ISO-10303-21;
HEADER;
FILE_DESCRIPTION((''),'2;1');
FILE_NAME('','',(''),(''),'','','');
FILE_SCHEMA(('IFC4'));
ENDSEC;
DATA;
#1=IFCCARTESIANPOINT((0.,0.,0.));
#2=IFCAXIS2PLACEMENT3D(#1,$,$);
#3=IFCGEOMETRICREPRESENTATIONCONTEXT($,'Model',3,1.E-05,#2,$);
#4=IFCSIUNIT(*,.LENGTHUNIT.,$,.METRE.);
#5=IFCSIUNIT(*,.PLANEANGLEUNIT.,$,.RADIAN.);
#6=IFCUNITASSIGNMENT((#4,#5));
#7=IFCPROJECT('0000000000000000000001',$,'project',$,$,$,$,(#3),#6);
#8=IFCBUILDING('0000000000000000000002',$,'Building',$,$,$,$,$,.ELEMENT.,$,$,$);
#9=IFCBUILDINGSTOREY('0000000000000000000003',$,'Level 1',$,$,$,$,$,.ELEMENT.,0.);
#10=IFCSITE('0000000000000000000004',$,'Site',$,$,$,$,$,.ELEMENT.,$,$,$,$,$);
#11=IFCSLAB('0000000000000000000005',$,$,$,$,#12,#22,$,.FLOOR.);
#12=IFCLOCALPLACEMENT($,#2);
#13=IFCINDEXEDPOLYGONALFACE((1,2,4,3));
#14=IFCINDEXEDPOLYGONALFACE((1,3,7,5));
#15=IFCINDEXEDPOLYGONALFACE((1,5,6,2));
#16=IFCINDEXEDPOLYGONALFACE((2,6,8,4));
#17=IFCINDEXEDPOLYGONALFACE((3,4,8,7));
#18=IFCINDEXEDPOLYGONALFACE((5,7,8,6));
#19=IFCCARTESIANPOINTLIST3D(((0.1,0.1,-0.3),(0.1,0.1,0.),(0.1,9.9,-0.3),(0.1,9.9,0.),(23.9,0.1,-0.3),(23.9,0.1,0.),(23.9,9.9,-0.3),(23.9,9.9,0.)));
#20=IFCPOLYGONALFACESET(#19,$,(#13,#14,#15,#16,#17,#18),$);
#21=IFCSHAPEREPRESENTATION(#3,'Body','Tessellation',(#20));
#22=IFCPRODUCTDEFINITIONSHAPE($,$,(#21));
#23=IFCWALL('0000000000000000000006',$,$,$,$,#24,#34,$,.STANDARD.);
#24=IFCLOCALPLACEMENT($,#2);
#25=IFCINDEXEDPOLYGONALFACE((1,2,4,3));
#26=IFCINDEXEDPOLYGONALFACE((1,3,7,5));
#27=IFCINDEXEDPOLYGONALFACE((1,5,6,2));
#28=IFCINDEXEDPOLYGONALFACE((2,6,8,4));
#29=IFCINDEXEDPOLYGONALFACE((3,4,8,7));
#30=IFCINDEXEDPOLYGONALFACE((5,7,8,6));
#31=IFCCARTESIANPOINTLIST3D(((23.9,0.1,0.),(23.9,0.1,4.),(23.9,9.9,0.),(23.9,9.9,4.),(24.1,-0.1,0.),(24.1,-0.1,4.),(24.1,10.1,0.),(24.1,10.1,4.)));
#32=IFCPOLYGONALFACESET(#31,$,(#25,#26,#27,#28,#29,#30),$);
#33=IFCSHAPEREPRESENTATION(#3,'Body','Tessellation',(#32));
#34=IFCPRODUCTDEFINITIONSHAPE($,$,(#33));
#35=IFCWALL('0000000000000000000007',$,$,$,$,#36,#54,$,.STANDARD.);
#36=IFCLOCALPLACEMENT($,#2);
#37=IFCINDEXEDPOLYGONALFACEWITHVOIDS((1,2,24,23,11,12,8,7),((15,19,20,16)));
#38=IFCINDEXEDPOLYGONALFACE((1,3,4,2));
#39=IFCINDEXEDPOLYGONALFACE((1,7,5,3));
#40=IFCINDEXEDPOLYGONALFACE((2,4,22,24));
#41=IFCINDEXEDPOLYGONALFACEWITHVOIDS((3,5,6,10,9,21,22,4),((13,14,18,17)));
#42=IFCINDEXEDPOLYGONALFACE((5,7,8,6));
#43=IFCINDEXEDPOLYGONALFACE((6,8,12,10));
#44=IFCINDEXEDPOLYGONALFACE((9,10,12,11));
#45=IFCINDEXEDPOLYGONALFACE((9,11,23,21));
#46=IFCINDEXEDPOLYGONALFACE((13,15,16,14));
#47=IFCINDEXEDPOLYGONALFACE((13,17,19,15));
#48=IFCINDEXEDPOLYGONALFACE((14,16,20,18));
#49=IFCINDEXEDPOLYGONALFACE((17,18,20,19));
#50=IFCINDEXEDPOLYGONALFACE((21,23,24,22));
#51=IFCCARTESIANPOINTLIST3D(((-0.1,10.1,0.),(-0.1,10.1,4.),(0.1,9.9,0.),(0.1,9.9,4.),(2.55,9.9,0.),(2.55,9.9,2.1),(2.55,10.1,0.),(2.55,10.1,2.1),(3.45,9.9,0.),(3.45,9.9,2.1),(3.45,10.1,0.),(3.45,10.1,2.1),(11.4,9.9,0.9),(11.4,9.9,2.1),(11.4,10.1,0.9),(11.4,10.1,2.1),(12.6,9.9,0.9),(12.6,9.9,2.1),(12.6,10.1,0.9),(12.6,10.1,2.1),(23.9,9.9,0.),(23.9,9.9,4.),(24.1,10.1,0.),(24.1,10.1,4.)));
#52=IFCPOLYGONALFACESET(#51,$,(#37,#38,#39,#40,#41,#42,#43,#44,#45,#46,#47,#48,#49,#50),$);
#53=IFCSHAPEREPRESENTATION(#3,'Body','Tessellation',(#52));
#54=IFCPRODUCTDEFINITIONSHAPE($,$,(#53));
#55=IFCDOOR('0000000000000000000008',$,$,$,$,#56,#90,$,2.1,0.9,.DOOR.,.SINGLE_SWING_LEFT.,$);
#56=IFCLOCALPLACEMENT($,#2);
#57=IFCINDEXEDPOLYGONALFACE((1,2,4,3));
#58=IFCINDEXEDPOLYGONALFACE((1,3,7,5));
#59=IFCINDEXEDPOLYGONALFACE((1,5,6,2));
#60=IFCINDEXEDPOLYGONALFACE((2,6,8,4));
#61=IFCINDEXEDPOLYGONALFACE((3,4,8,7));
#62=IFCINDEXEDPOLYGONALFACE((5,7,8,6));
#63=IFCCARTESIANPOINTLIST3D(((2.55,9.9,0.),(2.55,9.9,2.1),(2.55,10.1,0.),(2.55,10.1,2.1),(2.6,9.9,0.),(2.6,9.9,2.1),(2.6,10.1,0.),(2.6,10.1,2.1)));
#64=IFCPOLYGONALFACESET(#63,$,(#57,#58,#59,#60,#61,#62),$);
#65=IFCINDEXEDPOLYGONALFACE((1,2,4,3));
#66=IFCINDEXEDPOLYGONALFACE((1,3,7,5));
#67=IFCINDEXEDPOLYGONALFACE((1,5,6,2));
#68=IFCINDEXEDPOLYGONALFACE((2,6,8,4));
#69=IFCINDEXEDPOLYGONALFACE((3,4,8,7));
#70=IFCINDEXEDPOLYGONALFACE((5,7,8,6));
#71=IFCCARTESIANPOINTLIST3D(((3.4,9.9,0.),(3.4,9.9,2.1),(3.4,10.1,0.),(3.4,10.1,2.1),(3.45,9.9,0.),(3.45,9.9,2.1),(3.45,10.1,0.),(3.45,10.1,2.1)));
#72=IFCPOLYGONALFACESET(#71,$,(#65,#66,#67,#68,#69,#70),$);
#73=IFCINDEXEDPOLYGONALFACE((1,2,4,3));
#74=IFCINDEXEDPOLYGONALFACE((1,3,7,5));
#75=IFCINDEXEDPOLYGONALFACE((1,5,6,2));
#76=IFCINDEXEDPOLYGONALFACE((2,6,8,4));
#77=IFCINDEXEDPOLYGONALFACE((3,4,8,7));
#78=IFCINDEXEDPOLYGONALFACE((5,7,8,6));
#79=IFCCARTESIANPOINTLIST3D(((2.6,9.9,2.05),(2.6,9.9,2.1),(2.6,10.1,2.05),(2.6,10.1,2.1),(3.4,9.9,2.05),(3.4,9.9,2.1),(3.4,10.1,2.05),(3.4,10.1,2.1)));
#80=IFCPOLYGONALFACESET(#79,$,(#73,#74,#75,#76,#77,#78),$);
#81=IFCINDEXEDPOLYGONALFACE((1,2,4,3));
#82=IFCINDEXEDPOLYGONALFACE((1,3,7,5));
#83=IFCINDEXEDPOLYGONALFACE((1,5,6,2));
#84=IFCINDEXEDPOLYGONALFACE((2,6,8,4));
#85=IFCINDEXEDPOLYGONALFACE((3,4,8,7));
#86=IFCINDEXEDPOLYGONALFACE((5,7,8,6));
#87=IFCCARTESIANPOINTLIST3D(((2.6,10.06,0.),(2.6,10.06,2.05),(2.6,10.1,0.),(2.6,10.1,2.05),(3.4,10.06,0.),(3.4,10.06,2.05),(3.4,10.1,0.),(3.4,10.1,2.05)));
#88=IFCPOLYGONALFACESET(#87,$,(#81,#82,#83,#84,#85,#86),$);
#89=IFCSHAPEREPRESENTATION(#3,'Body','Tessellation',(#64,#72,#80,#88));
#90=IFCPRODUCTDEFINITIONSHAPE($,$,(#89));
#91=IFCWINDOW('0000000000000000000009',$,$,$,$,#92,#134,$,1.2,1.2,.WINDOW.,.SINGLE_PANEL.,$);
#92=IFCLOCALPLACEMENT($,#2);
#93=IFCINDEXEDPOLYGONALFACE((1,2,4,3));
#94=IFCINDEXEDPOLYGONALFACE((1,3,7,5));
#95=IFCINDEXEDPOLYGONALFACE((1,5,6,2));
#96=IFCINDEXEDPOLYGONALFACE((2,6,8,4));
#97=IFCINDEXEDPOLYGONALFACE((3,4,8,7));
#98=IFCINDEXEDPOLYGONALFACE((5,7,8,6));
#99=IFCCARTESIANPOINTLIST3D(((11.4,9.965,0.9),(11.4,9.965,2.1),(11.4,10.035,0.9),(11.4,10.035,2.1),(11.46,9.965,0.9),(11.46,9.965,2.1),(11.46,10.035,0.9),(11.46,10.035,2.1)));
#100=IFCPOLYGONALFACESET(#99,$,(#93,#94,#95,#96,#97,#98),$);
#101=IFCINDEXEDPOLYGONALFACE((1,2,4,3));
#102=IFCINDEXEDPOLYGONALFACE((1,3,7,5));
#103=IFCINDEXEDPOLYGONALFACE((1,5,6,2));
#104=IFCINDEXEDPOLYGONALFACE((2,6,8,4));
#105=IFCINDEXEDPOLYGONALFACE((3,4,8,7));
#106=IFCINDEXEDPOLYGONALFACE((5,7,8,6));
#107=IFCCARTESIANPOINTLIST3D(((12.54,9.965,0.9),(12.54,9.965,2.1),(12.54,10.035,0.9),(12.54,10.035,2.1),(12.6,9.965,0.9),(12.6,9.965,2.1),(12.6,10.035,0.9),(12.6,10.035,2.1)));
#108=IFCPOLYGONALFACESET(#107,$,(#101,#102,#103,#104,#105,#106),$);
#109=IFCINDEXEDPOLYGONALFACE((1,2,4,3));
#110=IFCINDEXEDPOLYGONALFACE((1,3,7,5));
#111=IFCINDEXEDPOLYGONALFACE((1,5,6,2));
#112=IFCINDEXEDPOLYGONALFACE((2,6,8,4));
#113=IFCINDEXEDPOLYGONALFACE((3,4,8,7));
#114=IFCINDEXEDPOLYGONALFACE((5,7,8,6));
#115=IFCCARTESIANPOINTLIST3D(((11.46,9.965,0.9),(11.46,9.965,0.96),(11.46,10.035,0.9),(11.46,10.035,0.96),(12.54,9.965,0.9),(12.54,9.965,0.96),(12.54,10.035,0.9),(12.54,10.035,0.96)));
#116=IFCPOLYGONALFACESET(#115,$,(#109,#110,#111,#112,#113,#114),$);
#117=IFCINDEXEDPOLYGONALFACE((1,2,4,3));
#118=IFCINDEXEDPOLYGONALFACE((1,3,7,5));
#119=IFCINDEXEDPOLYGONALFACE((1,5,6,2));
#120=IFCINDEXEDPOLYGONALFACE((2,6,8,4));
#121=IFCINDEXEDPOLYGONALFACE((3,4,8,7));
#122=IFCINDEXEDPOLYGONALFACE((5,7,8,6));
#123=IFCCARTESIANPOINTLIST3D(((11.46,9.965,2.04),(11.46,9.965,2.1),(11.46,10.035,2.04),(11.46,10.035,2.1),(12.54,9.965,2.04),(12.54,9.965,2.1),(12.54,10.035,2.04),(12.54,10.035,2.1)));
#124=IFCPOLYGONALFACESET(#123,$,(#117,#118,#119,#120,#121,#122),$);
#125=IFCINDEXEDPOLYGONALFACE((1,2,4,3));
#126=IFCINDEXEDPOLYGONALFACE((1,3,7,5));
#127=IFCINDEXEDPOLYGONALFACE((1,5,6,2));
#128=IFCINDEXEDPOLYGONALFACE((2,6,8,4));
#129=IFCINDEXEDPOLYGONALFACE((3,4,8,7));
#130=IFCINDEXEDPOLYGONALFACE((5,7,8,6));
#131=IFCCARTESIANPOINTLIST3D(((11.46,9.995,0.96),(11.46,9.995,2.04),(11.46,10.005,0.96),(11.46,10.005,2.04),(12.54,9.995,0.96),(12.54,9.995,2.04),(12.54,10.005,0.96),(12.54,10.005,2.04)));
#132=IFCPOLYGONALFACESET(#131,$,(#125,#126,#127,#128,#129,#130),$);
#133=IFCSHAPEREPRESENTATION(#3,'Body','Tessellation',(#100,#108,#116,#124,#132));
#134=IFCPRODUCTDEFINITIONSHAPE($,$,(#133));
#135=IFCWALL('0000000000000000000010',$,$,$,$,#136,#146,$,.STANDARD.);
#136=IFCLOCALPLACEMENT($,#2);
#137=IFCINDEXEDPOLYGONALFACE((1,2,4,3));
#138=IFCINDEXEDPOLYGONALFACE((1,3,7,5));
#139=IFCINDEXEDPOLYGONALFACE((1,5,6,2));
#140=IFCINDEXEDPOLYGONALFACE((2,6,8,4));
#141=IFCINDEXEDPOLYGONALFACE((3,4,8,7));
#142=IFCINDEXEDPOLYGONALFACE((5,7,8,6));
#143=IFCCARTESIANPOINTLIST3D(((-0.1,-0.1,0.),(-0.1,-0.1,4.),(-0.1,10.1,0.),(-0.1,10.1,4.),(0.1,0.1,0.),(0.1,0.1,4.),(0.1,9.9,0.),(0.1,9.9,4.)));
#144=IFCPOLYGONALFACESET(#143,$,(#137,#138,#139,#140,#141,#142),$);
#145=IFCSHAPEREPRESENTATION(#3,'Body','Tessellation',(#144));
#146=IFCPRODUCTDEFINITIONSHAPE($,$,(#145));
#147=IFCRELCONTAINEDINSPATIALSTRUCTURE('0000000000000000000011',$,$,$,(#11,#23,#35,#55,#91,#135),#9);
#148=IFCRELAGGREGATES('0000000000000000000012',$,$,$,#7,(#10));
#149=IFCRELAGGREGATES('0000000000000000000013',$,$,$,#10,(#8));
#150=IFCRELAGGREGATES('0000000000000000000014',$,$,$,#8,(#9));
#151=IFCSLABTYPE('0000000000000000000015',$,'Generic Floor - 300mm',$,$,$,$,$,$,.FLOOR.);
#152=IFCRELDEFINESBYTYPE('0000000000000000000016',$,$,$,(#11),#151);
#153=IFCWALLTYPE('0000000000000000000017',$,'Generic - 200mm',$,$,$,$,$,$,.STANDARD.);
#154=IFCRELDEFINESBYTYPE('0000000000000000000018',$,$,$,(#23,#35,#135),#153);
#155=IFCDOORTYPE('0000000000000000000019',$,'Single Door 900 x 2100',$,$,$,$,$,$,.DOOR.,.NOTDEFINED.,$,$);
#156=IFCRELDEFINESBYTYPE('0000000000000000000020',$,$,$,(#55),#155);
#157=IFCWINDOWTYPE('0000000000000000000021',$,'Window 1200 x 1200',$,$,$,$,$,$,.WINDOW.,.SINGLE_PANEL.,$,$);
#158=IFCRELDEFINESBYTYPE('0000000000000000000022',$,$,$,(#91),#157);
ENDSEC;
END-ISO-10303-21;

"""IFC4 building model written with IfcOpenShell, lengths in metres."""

from ifc_helpers import new_model, si_unit, frame, frame_2d, origin, origin_with_axes, origin_2d, place, context, project, spatial, polyline, rectangle, outline, extrude, type_object, element, fill, save


model = new_model("IFC4")

# Units and contexts
model_context = context("Model", 3, precision=1e-05, world=origin())
ifc_project = project(units=[si_unit("LENGTHUNIT", "METRE"), si_unit("PLANEANGLEUNIT", "RADIAN")], contexts=[model_context])

# Site, building, storey
site = spatial("IfcSite", under=ifc_project, Name="Site", CompositionType="ELEMENT")
building = spatial("IfcBuilding", under=site, Name="Building", CompositionType="ELEMENT")
storey = spatial("IfcBuildingStorey", under=building, Name="Level 1", CompositionType="ELEMENT", Elevation=0.0)

# Slab
slab_type = type_object("IfcSlabType", Name="Generic Floor - 300mm", PredefinedType="FLOOR")
slab_placement = place(None, origin())
element("IfcSlab", 1, at=slab_placement, inside=storey, type_object=slab_type, PredefinedType="FLOOR", context=model_context, shape_type="SweptSolid", body=[
    extrude(outline(polyline([(0.1, 0.1), (23.9, 0.1), (23.9, 9.9), (0.1, 9.9), (0.1, 0.1)])), origin(), (0.0, 0.0, -1.0), 0.3),
])

# Shared definitions
wall_type = type_object("IfcWallType", Name="Generic - 200mm", PredefinedType="STANDARD")

# Wall
wall_1_placement = place(None, frame((24.0, 10.0, 0.0), z_axis=(0.0, 0.0, 1.0), x_axis=(0.0, -1.0, 0.0)))
element("IfcWall", 2, at=wall_1_placement, inside=storey, type_object=wall_type, PredefinedType="STANDARD", context=model_context, shape_type="SweptSolid", body=[
    extrude(outline(polyline([(0.1, -0.1), (9.9, -0.1), (10.1, 0.1), (-0.1, 0.1), (0.1, -0.1)])), origin(), (0.0, 0.0, 1.0), 4.0),
])

# Wall, openings, door, window
wall_2_placement = place(None, frame((0.0, 10.0, 0.0), z_axis=(0.0, 0.0, 1.0), x_axis=(1.0, 0.0, 0.0)))
wall_2 = element("IfcWall", 3, at=wall_2_placement, inside=storey, type_object=wall_type, PredefinedType="STANDARD", context=model_context, shape_type="SweptSolid", body=[
    extrude(outline(polyline([(0.1, -0.1), (23.9, -0.1), (24.1, 0.1), (-0.1, 0.1), (0.1, -0.1)])), origin(), (0.0, 0.0, 1.0), 4.0),
])
opening_1_placement = place(wall_2_placement, frame((3.0, 0.0, 0.0), z_axis=(0.0, 0.0, 1.0), x_axis=(1.0, 0.0, 0.0)))
opening_1 = element("IfcOpeningElement", 4, at=opening_1_placement, cuts=wall_2, PredefinedType="OPENING", context=model_context, shape_type="SweptSolid", body=[
    extrude(rectangle(XDim=0.9, YDim=0.202, at=origin_2d()), origin(), (0.0, 0.0, 1.0), 2.1),
])
opening_2_placement = place(wall_2_placement, frame((12.0, 0.0, 0.9), z_axis=(0.0, 0.0, 1.0), x_axis=(1.0, 0.0, 0.0)))
opening_2 = element("IfcOpeningElement", 5, at=opening_2_placement, cuts=wall_2, PredefinedType="OPENING", context=model_context, shape_type="SweptSolid", body=[
    extrude(rectangle(XDim=1.2, YDim=0.202, at=origin_2d()), origin(), (0.0, 0.0, 1.0), 1.2),
])
door_type_1 = type_object("IfcDoorType", Name="Single Door 900 x 2100", OperationType="NOTDEFINED", PredefinedType="DOOR")
door_1_placement = place(opening_1_placement, origin_with_axes())
door_1 = element("IfcDoor", 6, at=door_1_placement, inside=storey, type_object=door_type_1, OperationType="SINGLE_SWING_LEFT", OverallHeight=2.1, OverallWidth=0.9, PredefinedType="DOOR", context=model_context, shape_type="SweptSolid", body=[
    extrude(rectangle(XDim=0.05, YDim=0.2, at=frame_2d((-0.425, 0.0))), origin(), (0.0, 0.0, 1.0), 2.1),
    extrude(rectangle(XDim=0.05, YDim=0.2, at=frame_2d((0.425, 0.0))), origin(), (0.0, 0.0, 1.0), 2.1),
    extrude(rectangle(XDim=0.8, YDim=0.2, at=origin_2d()), frame((0.0, 0.0, 2.05)), (0.0, 0.0, 1.0), 0.05),
    extrude(rectangle(XDim=0.8, YDim=0.04, at=frame_2d((0.0, 0.08))), origin(), (0.0, 0.0, 1.0), 2.05),
])
fill(opening_1, door_1)
window_type_1 = type_object("IfcWindowType", Name="Window 1200 x 1200", PartitioningType="SINGLE_PANEL", PredefinedType="WINDOW")
window_1_placement = place(opening_2_placement, origin_with_axes())
window_1 = element("IfcWindow", 7, at=window_1_placement, inside=storey, type_object=window_type_1, OverallHeight=1.2, OverallWidth=1.2, PartitioningType="SINGLE_PANEL", PredefinedType="WINDOW", context=model_context, shape_type="SweptSolid", body=[
    extrude(rectangle(XDim=0.06, YDim=0.07, at=frame_2d((-0.57, 0.0))), origin(), (0.0, 0.0, 1.0), 1.2),
    extrude(rectangle(XDim=0.06, YDim=0.07, at=frame_2d((0.57, 0.0))), origin(), (0.0, 0.0, 1.0), 1.2),
    extrude(rectangle(XDim=1.08, YDim=0.07, at=origin_2d()), origin(), (0.0, 0.0, 1.0), 0.06),
    extrude(rectangle(XDim=1.08, YDim=0.07, at=origin_2d()), frame((0.0, 0.0, 1.14)), (0.0, 0.0, 1.0), 0.06),
    extrude(rectangle(XDim=1.08, YDim=0.01, at=origin_2d()), frame((0.0, 0.0, 0.06)), (0.0, 0.0, 1.0), 1.08),
])
fill(opening_2, window_1)

# Wall
wall_3_placement = place(None, frame((0.0, 0.0, 0.0), z_axis=(0.0, 0.0, 1.0), x_axis=(0.0, 1.0, 0.0)))
element("IfcWall", 8, at=wall_3_placement, inside=storey, type_object=wall_type, PredefinedType="STANDARD", context=model_context, shape_type="SweptSolid", body=[
    extrude(outline(polyline([(0.1, -0.1), (9.9, -0.1), (10.1, 0.1), (-0.1, 0.1), (0.1, -0.1)])), origin(), (0.0, 0.0, 1.0), 4.0),
])

save(model, "model.ifc")
